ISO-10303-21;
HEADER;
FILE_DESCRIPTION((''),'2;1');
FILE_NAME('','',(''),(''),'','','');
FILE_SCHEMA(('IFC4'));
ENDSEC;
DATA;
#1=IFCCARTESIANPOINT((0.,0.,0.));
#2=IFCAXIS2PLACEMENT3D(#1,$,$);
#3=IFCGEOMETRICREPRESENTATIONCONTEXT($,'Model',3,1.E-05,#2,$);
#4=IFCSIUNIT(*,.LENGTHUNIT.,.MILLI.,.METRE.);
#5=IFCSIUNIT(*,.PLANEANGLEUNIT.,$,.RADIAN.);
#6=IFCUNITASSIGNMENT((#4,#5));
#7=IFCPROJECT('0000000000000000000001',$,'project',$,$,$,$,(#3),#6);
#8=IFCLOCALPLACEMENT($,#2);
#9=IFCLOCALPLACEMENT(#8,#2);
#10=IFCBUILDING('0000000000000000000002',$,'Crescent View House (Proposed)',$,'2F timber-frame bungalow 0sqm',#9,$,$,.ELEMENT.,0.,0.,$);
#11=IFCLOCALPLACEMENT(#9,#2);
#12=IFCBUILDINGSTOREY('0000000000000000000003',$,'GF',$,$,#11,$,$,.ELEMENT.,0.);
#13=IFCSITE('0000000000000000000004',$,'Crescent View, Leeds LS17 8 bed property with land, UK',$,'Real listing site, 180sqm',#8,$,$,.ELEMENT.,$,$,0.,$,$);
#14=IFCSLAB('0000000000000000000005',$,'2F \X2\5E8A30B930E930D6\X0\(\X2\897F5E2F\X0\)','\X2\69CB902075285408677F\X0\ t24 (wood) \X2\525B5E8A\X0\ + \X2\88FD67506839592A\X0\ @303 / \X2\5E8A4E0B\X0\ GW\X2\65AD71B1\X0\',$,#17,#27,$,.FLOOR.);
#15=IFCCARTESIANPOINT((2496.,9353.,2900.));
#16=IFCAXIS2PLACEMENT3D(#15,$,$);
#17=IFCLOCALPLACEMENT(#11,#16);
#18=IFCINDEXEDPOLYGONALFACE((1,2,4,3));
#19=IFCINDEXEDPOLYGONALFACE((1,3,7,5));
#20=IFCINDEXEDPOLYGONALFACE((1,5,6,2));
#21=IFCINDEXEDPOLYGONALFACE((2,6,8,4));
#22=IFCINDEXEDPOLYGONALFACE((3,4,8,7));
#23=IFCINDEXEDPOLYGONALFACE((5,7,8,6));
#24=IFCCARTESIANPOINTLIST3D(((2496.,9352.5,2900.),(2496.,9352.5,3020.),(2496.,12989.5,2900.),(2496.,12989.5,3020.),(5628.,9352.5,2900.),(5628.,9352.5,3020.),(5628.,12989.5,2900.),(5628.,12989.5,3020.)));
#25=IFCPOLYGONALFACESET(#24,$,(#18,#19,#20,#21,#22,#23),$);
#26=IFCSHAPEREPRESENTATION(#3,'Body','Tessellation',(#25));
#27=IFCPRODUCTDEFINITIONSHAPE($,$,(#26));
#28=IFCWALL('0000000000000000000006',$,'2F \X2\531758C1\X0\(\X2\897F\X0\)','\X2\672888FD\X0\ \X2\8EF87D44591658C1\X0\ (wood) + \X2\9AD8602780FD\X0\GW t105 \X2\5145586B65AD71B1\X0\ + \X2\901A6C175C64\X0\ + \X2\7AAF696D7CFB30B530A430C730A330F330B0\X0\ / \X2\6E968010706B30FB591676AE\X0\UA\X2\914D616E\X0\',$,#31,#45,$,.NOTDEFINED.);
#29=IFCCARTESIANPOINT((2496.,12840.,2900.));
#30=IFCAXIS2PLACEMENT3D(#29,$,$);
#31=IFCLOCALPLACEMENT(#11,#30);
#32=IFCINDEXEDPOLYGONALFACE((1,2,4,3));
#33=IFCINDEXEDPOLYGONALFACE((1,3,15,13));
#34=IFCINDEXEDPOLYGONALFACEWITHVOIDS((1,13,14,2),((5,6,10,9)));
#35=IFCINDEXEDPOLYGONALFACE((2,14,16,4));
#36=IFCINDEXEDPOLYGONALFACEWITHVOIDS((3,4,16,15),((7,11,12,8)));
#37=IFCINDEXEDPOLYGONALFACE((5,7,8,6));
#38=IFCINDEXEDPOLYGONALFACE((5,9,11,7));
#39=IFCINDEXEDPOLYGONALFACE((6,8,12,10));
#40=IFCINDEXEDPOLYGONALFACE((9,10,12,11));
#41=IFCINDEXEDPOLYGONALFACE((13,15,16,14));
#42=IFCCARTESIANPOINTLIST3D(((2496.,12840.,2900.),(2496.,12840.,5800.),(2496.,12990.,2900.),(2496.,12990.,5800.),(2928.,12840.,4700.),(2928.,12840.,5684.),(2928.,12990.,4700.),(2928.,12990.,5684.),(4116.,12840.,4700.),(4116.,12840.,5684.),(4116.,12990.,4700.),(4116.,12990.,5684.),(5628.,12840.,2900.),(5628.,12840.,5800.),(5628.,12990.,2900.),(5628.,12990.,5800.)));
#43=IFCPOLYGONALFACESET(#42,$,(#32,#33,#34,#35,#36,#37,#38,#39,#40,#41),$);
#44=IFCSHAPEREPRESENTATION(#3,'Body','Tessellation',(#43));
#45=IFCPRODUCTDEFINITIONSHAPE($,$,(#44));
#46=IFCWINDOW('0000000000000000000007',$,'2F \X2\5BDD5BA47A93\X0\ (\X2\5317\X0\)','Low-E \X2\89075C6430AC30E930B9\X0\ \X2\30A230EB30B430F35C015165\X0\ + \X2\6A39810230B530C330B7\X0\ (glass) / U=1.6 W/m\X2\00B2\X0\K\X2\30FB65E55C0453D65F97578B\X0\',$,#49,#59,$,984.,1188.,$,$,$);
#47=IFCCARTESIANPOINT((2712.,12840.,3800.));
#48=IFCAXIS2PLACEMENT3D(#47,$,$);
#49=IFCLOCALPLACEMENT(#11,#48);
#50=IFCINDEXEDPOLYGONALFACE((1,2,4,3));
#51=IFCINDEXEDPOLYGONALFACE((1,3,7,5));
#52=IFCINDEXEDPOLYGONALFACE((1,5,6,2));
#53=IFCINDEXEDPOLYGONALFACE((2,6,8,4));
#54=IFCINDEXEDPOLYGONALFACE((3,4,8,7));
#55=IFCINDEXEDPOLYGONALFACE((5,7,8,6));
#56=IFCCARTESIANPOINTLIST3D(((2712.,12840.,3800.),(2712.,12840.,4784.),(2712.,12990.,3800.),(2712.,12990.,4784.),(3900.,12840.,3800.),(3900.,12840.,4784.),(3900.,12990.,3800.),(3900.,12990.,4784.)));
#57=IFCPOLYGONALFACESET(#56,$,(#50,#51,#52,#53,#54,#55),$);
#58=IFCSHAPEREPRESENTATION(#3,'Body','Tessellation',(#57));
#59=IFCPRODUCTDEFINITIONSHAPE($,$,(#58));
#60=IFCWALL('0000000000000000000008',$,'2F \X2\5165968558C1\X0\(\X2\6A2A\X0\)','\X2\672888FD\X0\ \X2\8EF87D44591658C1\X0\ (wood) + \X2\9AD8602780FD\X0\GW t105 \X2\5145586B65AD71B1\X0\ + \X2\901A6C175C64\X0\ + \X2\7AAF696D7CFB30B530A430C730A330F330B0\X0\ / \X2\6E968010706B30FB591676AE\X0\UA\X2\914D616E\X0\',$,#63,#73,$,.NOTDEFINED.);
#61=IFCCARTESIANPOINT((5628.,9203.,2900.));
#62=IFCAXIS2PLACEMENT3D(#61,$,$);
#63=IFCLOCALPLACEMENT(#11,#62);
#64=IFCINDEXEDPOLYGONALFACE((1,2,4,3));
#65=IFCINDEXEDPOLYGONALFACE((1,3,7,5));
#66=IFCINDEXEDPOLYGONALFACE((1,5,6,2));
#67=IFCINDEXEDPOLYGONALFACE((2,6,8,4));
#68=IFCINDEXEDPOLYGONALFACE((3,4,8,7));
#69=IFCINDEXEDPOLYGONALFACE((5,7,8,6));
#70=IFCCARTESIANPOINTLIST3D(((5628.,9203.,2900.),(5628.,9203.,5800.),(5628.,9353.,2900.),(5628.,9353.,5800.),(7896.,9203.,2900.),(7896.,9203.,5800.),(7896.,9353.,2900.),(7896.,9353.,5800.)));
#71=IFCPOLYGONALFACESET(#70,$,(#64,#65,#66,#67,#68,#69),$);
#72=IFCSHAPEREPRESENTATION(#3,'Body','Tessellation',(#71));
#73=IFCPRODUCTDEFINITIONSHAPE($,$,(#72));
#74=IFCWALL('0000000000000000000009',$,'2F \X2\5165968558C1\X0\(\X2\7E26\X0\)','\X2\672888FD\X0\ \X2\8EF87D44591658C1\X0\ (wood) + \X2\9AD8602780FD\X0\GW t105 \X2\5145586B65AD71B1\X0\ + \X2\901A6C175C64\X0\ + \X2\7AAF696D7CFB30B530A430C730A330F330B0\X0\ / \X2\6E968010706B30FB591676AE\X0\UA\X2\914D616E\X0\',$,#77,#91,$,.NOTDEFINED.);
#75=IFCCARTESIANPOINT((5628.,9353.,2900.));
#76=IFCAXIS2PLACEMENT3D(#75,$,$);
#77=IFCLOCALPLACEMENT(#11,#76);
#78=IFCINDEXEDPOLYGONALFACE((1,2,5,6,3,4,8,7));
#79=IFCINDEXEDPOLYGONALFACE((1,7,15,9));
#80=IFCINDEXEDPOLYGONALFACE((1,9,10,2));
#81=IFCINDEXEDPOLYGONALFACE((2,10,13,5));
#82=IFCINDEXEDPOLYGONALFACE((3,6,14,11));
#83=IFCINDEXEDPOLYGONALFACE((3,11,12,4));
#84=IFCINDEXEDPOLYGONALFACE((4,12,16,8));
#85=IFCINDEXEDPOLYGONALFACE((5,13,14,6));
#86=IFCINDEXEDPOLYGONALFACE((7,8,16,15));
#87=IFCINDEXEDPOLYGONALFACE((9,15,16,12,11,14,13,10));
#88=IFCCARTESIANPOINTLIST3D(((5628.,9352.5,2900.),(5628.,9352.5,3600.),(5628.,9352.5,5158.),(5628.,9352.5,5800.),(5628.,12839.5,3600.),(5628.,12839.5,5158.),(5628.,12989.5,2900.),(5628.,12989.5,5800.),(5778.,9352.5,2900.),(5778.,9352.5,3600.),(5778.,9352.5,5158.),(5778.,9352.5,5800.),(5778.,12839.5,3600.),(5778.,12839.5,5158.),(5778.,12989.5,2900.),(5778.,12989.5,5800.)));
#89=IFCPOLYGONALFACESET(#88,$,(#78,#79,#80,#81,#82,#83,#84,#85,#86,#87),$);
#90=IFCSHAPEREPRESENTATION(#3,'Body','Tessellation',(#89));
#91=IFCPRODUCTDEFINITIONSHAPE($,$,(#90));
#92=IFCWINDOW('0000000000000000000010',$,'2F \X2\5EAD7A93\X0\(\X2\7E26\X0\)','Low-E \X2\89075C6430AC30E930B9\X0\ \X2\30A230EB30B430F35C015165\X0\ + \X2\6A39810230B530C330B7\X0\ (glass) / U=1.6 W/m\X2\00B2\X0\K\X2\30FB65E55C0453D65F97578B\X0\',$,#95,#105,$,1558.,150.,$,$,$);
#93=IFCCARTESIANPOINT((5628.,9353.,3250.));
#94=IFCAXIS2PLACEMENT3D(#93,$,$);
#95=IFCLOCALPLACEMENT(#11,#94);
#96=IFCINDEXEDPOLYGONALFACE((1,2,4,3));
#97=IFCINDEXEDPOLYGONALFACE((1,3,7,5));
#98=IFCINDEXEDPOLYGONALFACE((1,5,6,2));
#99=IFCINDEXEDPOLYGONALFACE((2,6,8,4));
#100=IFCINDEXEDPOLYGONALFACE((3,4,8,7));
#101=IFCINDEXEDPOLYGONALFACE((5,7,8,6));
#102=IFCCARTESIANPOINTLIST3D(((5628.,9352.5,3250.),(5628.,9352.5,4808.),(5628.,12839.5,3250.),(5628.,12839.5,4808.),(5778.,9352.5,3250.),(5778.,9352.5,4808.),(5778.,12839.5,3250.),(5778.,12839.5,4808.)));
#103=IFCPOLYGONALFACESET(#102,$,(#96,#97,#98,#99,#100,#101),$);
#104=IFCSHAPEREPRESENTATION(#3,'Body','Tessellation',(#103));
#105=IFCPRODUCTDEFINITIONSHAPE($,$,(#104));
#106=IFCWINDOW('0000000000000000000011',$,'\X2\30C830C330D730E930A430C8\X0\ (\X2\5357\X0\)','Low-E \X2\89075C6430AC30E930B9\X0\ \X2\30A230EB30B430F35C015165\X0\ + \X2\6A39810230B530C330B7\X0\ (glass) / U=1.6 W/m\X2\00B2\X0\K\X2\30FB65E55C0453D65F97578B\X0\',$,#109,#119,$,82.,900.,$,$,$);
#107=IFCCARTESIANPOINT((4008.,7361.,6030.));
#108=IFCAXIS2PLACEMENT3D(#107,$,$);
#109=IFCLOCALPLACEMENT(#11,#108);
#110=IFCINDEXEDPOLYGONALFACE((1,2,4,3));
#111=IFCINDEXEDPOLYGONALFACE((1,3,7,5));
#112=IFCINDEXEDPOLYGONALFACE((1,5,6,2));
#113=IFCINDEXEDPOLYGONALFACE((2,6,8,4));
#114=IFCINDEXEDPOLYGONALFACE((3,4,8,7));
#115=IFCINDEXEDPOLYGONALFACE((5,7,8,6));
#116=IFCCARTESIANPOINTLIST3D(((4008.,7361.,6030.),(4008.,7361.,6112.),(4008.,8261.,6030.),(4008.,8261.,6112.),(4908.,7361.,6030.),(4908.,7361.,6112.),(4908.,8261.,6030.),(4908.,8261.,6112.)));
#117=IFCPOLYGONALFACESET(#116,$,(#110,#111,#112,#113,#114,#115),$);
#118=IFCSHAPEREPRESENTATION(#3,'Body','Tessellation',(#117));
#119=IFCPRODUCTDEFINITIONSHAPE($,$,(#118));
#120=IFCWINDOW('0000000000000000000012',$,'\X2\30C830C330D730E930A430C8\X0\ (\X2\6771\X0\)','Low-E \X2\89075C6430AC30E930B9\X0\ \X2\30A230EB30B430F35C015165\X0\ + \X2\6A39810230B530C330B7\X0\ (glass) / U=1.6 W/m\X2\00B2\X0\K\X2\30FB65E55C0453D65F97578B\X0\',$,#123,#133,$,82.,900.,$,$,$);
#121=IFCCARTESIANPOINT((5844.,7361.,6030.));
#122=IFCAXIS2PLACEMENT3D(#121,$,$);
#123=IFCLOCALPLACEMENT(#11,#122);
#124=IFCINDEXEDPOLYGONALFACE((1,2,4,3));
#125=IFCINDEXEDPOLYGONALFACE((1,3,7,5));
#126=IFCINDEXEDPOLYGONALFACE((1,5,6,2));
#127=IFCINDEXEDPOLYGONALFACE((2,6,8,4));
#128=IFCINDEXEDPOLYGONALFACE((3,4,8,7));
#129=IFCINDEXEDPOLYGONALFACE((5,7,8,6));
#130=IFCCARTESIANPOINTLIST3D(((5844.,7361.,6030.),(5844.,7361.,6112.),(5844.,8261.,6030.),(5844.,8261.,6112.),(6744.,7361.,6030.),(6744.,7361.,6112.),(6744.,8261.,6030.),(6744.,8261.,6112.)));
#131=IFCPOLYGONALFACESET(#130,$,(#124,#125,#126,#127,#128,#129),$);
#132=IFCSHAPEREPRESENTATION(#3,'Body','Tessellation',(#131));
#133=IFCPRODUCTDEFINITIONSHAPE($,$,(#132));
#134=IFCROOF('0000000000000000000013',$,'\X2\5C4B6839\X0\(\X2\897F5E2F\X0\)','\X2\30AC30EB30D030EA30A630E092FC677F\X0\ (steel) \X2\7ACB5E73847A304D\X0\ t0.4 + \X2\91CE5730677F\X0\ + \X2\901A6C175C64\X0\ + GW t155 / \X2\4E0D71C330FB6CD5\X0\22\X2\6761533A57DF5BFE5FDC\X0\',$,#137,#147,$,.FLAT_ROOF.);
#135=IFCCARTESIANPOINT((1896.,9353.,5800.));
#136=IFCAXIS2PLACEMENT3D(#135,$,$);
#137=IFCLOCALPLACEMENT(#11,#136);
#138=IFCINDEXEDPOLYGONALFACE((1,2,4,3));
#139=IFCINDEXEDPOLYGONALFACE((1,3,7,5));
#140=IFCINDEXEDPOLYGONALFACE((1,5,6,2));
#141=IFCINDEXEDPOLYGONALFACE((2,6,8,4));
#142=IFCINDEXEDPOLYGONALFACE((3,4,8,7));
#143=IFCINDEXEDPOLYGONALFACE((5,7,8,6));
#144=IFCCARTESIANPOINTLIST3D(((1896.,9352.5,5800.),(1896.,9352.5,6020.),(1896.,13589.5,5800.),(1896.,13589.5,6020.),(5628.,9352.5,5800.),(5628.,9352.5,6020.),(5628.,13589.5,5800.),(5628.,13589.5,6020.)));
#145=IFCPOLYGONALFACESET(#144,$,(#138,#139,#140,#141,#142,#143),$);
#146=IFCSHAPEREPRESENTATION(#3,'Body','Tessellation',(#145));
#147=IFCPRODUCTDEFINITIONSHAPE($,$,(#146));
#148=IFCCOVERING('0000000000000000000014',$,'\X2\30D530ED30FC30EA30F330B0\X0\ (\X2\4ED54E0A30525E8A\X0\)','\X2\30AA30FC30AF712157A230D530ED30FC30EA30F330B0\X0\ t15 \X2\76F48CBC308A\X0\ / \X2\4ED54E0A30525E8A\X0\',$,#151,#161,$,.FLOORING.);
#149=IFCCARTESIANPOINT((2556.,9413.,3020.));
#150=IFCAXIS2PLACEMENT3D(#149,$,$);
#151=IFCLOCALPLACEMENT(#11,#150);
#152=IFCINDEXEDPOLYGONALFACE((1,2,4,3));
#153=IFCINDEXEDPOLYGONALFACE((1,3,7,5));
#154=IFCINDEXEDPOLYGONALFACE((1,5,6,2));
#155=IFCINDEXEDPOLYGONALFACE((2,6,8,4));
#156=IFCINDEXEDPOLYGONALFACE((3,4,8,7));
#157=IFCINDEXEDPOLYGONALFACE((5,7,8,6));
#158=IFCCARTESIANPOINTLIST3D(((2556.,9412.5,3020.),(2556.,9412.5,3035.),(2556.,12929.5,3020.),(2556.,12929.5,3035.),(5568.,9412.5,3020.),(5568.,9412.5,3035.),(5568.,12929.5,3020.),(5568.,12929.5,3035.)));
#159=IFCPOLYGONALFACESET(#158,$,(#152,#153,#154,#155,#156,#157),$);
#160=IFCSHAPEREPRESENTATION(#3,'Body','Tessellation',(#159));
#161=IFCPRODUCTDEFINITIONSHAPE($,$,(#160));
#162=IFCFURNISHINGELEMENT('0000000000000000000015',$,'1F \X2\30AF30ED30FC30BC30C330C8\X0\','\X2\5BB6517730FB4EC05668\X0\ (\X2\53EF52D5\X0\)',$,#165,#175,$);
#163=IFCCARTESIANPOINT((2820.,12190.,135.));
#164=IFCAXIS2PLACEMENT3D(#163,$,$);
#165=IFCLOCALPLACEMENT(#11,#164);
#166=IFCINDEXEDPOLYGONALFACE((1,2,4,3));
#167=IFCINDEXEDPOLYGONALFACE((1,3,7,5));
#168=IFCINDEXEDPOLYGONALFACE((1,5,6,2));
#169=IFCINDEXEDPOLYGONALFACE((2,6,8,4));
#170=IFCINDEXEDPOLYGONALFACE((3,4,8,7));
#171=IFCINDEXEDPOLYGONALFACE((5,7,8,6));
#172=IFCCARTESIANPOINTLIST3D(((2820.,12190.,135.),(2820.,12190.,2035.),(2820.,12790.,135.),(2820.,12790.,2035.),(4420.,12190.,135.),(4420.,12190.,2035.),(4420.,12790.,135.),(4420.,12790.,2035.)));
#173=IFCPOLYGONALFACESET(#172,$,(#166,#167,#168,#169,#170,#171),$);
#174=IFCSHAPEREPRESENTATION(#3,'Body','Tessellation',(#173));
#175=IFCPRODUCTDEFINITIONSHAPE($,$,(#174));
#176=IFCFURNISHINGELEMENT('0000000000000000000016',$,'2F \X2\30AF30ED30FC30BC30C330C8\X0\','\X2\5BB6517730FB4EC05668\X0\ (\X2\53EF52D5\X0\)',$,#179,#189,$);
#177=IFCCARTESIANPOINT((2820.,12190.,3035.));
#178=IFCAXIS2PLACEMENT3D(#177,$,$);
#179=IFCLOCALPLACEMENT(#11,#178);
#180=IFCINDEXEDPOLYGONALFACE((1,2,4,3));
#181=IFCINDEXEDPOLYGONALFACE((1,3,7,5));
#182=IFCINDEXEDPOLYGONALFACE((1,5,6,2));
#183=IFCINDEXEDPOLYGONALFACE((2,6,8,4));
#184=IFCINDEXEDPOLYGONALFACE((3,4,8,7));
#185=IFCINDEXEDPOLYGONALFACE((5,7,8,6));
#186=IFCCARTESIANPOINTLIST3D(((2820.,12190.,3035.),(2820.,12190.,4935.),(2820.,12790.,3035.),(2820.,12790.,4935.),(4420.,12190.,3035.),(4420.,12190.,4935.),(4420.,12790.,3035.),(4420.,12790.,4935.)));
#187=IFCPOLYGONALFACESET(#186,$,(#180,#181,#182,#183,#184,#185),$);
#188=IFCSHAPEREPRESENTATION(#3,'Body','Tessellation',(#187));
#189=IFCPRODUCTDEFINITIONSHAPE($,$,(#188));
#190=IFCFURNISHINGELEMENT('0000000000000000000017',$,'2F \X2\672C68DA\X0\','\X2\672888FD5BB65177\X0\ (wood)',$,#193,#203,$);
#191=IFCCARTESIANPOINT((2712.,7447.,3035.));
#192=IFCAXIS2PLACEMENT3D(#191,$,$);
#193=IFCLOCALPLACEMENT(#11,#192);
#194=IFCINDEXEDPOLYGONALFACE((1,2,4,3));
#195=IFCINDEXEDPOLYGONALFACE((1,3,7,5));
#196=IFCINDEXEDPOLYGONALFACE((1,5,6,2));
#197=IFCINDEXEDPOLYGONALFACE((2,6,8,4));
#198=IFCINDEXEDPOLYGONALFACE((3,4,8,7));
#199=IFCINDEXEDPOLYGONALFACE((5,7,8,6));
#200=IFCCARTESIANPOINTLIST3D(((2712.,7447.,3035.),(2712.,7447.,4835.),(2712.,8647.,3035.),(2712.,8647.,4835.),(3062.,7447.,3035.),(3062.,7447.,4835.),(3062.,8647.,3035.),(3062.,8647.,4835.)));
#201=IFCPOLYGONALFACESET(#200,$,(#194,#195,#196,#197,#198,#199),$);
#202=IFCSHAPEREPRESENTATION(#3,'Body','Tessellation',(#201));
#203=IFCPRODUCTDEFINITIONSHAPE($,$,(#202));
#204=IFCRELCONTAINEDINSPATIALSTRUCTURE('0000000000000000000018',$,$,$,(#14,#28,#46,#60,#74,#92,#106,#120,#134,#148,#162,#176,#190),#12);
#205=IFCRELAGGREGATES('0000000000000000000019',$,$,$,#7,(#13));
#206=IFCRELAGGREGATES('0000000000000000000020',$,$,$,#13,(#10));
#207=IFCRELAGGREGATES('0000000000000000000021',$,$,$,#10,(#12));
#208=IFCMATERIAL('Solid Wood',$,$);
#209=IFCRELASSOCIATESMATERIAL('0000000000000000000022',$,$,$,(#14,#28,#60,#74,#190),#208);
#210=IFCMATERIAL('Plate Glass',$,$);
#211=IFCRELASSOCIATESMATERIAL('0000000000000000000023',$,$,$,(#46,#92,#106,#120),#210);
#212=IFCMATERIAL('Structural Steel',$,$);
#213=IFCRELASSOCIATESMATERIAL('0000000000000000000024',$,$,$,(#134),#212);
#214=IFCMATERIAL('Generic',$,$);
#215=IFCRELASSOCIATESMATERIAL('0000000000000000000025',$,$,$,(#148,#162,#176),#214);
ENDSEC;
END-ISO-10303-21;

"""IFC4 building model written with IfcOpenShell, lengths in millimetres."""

from ifc_helpers import new_model, si_unit, frame, frame_2d, origin, place, context, project, spatial, rectangle, extrude, material, element, fill, save


model = new_model("IFC4")

# Units and contexts
model_context = context("Model", 3, precision=1e-05, world=origin())
ifc_project = project(units=[si_unit("LENGTHUNIT", "METRE", prefix="MILLI"), si_unit("PLANEANGLEUNIT", "RADIAN")], contexts=[model_context])

# Site, building, storey
site_placement = place(None, origin())
site = spatial("IfcSite", under=ifc_project, at=site_placement, Name="Crescent View, Leeds LS17 8 bed property with land, UK", ObjectType="Real listing site, 180sqm", CompositionType="ELEMENT", RefElevation=0.0)
building_placement = place(site_placement, origin())
building = spatial("IfcBuilding", under=site, at=building_placement, Name="Crescent View House (Proposed)", ObjectType="2F timber-frame bungalow 0sqm", CompositionType="ELEMENT", ElevationOfRefHeight=0.0, ElevationOfTerrain=0.0)
storey_placement = place(building_placement, origin())
storey = spatial("IfcBuildingStorey", under=building, at=storey_placement, Name="GF", CompositionType="ELEMENT", Elevation=0.0)

# Slab
ifc_material_1 = material(Name="Solid Wood")
slab_placement = place(storey_placement, frame((2496.0, 9353.0, 2900.0)))
element("IfcSlab", 1, at=slab_placement, inside=storey, material=ifc_material_1, Name="2F 床スラブ(西帯)", Description="構造用合板 t24 (wood) 剛床 + 製材根太 @303 / 床下 GW断熱", PredefinedType="FLOOR", context=model_context, shape_type="SweptSolid", body=[
    extrude(rectangle(XDim=3132.0, YDim=3637.0, at=frame_2d((1566.0, 1818.0))), frame((2496.0, 9353.0, 2900.0)), (0.0, 0.0, 1.0), 120.0),
])

# Wall, opening, window
wall_1_placement = place(storey_placement, frame((2496.0, 12840.0, 2900.0)))
wall_1 = element("IfcWall", 2, at=wall_1_placement, inside=storey, material=ifc_material_1, Name="2F 北壁(西)", Description="木製 軸組外壁 (wood) + 高性能GW t105 充填断熱 + 通気層 + 窯業系サイディング / 準耐火・外皮UA配慮", PredefinedType="NOTDEFINED", context=model_context, shape_type="SweptSolid", body=[
    extrude(rectangle(XDim=3132.0, YDim=150.0, at=frame_2d((1566.0, 75.0))), frame((2496.0, 12840.0, 2900.0)), (0.0, 0.0, 1.0), 2900.0),
])
opening_1_placement = place(storey_placement, frame((2712.0, 12840.0, 3800.0)))
opening_1 = element("IfcOpeningElement", 3, at=opening_1_placement, cuts=wall_1, PredefinedType="NOTDEFINED", context=model_context, shape_type="SweptSolid", body=[
    extrude(rectangle(XDim=1188.0, YDim=150.0, at=frame_2d((594.0, 75.0))), frame((2712.0, 12840.0, 3800.0)), (0.0, 0.0, 1.0), 984.0),
])
ifc_material_2 = material(Name="Plate Glass")
window_1_placement = place(storey_placement, frame((2712.0, 12840.0, 3800.0)))
window_1 = element("IfcWindow", 4, at=window_1_placement, inside=storey, material=ifc_material_2, Name="2F 寝室窓 (北)", Description="Low-E 複層ガラス アルゴン封入 + 樹脂サッシ (glass) / U=1.6 W/m²K・日射取得型", OverallHeight=984.0, OverallWidth=1188.0, context=model_context, shape_type="SweptSolid", body=[
    extrude(rectangle(XDim=1188.0, YDim=150.0, at=frame_2d((594.0, 75.0))), frame((2712.0, 12840.0, 3800.0)), (0.0, 0.0, 1.0), 984.0),
])
fill(opening_1, window_1)

# Wall
wall_2_placement = place(storey_placement, frame((5628.0, 9203.0, 2900.0)))
element("IfcWall", 5, at=wall_2_placement, inside=storey, material=ifc_material_1, Name="2F 入隅壁(横)", Description="木製 軸組外壁 (wood) + 高性能GW t105 充填断熱 + 通気層 + 窯業系サイディング / 準耐火・外皮UA配慮", PredefinedType="NOTDEFINED", context=model_context, shape_type="SweptSolid", body=[
    extrude(rectangle(XDim=2268.0, YDim=150.0, at=frame_2d((1134.0, 75.0))), frame((5628.0, 9203.0, 2900.0)), (0.0, 0.0, 1.0), 2900.0),
])

# Wall, opening, window
wall_3_placement = place(storey_placement, frame((5628.0, 9353.0, 2900.0)))
wall_3 = element("IfcWall", 6, at=wall_3_placement, inside=storey, material=ifc_material_1, Name="2F 入隅壁(縦)", Description="木製 軸組外壁 (wood) + 高性能GW t105 充填断熱 + 通気層 + 窯業系サイディング / 準耐火・外皮UA配慮", PredefinedType="NOTDEFINED", context=model_context, shape_type="SweptSolid", body=[
    extrude(rectangle(XDim=150.0, YDim=3637.0, at=frame_2d((75.0, 1818.0))), frame((5628.0, 9353.0, 2900.0)), (0.0, 0.0, 1.0), 2900.0),
])
opening_2_placement = place(storey_placement, frame((5628.0, 9353.0, 3250.0)))
opening_2 = element("IfcOpeningElement", 7, at=opening_2_placement, cuts=wall_3, PredefinedType="NOTDEFINED", context=model_context, shape_type="SweptSolid", body=[
    extrude(rectangle(XDim=150.0, YDim=3487.0, at=frame_2d((75.0, 1743.0))), frame((5628.0, 9353.0, 3250.0)), (0.0, 0.0, 1.0), 1558.0),
])
window_2_placement = place(storey_placement, frame((5628.0, 9353.0, 3250.0)))
window_2 = element("IfcWindow", 8, at=window_2_placement, inside=storey, material=ifc_material_2, Name="2F 庭窓(縦)", Description="Low-E 複層ガラス アルゴン封入 + 樹脂サッシ (glass) / U=1.6 W/m²K・日射取得型", OverallHeight=1558.0, OverallWidth=150.0, context=model_context, shape_type="SweptSolid", body=[
    extrude(rectangle(XDim=150.0, YDim=3487.0, at=frame_2d((75.0, 1743.0))), frame((5628.0, 9353.0, 3250.0)), (0.0, 0.0, 1.0), 1558.0),
])
fill(opening_2, window_2)

# Windows
window_3_placement = place(storey_placement, frame((4008.0, 7361.0, 6030.0)))
element("IfcWindow", 9, at=window_3_placement, inside=storey, material=ifc_material_2, Name="トップライト (南)", Description="Low-E 複層ガラス アルゴン封入 + 樹脂サッシ (glass) / U=1.6 W/m²K・日射取得型", OverallHeight=82.0, OverallWidth=900.0, context=model_context, shape_type="SweptSolid", body=[
    extrude(rectangle(XDim=900.0, YDim=900.0, at=frame_2d((450.0, 450.0))), frame((4008.0, 7361.0, 6030.0)), (0.0, 0.0, 1.0), 82.0),
])
window_4_placement = place(storey_placement, frame((5844.0, 7361.0, 6030.0)))
element("IfcWindow", 10, at=window_4_placement, inside=storey, material=ifc_material_2, Name="トップライト (東)", Description="Low-E 複層ガラス アルゴン封入 + 樹脂サッシ (glass) / U=1.6 W/m²K・日射取得型", OverallHeight=82.0, OverallWidth=900.0, context=model_context, shape_type="SweptSolid", body=[
    extrude(rectangle(XDim=900.0, YDim=900.0, at=frame_2d((450.0, 450.0))), frame((5844.0, 7361.0, 6030.0)), (0.0, 0.0, 1.0), 82.0),
])

# Roof
ifc_material_3 = material(Name="Structural Steel")
for number, where, name in (
    (11, (1896.0, 9353.0, 5800.0), "屋根(西帯)"),
):
    element("IfcRoof", number, at=place(storey_placement, frame(where)), inside=storey, material=ifc_material_3, Name=name, Description="ガルバリウム鋼板 (steel) 立平葺き t0.4 + 野地板 + 通気層 + GW t155 / 不燃・法22条区域対応", PredefinedType="FLAT_ROOF", context=model_context, shape_type="SweptSolid", body=[
        extrude(rectangle(XDim=3732.0, YDim=4237.0, at=frame_2d((1866.0, 2118.0))), frame((1896.0, 9353.0, 5800.0)), (0.0, 0.0, 1.0), 220.0),
    ])

# Covering
ifc_material_4 = material(Name="Generic")
covering_placement = place(storey_placement, frame((2556.0, 9413.0, 3020.0)))
element("IfcCovering", 12, at=covering_placement, inside=storey, material=ifc_material_4, Name="フローリング (仕上げ床)", Description="オーク無垢フローリング t15 直貼り / 仕上げ床", PredefinedType="FLOORING", context=model_context, shape_type="SweptSolid", body=[
    extrude(rectangle(XDim=3012.0, YDim=3517.0, at=frame_2d((1506.0, 1758.0))), frame((2556.0, 9413.0, 3020.0)), (0.0, 0.0, 1.0), 15.0),
])

# Furnishing elements
furnishing_1_placement = place(storey_placement, frame((2820.0, 12190.0, 135.0)))
element("IfcFurnishingElement", 13, at=furnishing_1_placement, inside=storey, material=ifc_material_4, Name="1F クローゼット", Description="家具・什器 (可動)", context=model_context, shape_type="SweptSolid", body=[
    extrude(rectangle(XDim=1600.0, YDim=600.0, at=frame_2d((800.0, 300.0))), frame((2820.0, 12190.0, 135.0)), (0.0, 0.0, 1.0), 1900.0),
])
furnishing_2_placement = place(storey_placement, frame((2820.0, 12190.0, 3035.0)))
element("IfcFurnishingElement", 14, at=furnishing_2_placement, inside=storey, material=ifc_material_4, Name="2F クローゼット", Description="家具・什器 (可動)", context=model_context, shape_type="SweptSolid", body=[
    extrude(rectangle(XDim=1600.0, YDim=600.0, at=frame_2d((800.0, 300.0))), frame((2820.0, 12190.0, 3035.0)), (0.0, 0.0, 1.0), 1900.0),
])
furnishing_3_placement = place(storey_placement, frame((2712.0, 7447.0, 3035.0)))
element("IfcFurnishingElement", 15, at=furnishing_3_placement, inside=storey, material=ifc_material_1, Name="2F 本棚", Description="木製家具 (wood)", context=model_context, shape_type="SweptSolid", body=[
    extrude(rectangle(XDim=350.0, YDim=1200.0, at=frame_2d((175.0, 600.0))), frame((2712.0, 7447.0, 3035.0)), (0.0, 0.0, 1.0), 1800.0),
])

save(model, "model.ifc")
